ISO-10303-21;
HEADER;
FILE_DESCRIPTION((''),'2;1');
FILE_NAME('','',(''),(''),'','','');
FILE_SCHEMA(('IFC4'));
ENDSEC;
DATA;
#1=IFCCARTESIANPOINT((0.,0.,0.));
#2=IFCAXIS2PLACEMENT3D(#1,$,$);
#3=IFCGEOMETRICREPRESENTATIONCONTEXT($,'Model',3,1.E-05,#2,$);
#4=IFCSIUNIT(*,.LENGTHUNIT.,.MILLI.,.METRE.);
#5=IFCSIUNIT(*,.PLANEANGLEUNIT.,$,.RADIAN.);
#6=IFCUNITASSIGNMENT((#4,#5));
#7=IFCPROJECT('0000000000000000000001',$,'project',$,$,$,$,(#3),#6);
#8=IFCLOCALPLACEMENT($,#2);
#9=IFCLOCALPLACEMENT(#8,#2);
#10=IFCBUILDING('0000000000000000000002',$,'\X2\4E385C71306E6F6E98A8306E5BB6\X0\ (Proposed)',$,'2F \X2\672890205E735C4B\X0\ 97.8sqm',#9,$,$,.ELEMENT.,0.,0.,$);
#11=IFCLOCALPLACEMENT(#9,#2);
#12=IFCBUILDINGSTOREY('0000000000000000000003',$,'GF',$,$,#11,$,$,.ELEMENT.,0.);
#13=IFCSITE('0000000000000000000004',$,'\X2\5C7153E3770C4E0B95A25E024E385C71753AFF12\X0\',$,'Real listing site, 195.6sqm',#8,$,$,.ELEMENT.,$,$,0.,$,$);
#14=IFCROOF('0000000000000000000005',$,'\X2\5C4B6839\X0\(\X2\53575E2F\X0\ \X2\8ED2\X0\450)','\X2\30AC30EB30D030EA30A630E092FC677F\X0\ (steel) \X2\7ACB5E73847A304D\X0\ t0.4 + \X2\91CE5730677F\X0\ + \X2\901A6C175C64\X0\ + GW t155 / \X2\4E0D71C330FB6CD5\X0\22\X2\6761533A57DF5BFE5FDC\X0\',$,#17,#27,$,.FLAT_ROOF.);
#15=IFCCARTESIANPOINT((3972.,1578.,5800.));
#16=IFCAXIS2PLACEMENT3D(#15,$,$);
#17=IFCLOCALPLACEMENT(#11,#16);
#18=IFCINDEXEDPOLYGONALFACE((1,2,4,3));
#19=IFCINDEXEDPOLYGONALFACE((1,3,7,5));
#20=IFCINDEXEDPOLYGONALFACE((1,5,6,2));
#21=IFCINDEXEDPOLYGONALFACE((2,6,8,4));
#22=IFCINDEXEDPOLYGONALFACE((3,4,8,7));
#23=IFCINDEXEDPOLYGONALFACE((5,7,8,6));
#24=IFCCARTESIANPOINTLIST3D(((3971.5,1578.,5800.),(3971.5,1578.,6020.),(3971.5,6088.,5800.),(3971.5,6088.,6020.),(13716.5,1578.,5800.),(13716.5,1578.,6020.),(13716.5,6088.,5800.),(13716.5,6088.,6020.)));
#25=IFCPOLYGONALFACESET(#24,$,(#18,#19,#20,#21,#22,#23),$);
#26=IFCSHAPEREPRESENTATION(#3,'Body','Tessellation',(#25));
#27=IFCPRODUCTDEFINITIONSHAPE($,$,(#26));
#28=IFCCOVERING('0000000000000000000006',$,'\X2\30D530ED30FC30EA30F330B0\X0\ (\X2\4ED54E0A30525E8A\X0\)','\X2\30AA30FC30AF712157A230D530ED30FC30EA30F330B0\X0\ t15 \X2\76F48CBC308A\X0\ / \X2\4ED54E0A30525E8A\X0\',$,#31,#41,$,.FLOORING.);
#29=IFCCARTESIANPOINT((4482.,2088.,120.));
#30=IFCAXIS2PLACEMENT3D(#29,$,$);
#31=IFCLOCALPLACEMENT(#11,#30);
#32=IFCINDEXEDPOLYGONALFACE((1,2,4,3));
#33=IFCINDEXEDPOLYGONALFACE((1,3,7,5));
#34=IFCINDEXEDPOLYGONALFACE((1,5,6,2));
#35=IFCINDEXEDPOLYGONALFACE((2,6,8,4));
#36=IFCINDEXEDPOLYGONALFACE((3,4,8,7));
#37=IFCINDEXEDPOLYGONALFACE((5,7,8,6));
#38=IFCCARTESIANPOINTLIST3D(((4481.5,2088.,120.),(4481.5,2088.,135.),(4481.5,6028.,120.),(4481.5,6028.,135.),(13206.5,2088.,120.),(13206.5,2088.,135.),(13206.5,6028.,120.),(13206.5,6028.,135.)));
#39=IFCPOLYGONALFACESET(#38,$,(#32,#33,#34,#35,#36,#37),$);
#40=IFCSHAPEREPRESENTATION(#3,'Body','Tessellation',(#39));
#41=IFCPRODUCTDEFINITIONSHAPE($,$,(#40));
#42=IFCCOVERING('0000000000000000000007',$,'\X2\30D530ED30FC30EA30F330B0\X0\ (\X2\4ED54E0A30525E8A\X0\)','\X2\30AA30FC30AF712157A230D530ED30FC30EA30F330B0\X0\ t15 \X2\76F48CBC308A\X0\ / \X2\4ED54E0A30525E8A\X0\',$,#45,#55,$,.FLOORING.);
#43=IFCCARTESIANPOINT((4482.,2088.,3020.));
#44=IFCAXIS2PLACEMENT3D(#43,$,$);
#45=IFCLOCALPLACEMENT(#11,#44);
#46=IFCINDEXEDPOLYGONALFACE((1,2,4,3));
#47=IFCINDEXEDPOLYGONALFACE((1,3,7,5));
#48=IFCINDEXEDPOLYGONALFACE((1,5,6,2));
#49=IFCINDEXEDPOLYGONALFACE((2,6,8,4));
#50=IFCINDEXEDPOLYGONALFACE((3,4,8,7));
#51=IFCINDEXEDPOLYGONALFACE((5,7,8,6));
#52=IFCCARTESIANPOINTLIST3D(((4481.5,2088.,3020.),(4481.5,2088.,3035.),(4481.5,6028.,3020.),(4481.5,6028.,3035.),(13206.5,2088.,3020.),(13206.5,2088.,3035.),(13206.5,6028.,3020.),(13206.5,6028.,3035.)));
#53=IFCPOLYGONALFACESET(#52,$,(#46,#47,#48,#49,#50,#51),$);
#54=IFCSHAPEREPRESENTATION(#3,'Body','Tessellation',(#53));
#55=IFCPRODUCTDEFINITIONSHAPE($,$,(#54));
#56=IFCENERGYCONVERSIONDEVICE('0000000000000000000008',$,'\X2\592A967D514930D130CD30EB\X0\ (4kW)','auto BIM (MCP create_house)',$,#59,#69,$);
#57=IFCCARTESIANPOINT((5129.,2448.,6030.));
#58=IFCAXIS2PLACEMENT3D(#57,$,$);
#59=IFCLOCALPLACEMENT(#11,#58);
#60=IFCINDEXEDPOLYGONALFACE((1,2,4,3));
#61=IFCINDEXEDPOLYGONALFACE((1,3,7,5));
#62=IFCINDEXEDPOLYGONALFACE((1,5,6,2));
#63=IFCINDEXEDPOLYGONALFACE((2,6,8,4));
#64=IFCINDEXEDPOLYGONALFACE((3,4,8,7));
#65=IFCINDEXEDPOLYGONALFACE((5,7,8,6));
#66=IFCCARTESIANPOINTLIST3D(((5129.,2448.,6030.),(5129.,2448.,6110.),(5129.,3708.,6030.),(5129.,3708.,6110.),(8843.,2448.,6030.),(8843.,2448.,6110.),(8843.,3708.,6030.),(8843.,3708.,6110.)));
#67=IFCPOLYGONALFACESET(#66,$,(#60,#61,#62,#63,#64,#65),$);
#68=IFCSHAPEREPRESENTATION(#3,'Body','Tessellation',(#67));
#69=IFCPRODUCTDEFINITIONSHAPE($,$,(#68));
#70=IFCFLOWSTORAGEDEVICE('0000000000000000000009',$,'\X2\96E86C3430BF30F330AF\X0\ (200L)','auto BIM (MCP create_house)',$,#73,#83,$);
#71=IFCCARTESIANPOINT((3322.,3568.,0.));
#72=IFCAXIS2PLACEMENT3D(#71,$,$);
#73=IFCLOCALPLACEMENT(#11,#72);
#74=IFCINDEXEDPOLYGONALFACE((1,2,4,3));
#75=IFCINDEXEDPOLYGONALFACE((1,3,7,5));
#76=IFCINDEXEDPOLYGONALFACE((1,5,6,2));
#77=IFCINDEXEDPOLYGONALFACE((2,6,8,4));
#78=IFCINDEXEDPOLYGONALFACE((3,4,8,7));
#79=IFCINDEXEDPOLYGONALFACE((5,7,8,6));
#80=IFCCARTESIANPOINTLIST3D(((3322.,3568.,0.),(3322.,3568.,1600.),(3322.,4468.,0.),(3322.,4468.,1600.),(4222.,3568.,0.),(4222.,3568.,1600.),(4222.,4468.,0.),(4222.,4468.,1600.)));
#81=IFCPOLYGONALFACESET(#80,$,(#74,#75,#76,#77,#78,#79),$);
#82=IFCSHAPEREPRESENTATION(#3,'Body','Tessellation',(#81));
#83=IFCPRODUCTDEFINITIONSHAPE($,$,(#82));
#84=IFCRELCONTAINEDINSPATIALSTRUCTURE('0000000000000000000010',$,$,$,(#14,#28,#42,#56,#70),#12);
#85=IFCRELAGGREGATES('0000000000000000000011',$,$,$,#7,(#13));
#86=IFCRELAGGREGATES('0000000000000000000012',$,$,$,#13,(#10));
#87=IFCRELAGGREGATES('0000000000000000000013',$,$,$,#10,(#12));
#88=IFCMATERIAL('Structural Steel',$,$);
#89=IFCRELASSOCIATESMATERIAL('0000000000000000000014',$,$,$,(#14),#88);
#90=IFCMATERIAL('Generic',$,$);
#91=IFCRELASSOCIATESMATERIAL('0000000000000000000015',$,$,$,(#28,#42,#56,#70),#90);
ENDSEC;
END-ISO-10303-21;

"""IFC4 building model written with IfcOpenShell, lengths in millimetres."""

from ifc_helpers import new_model, si_unit, frame, frame_2d, origin, place, context, project, spatial, rectangle, extrude, material, element, save


model = new_model("IFC4")

# Units and contexts
model_context = context("Model", 3, precision=1e-05, world=origin())
ifc_project = project(units=[si_unit("LENGTHUNIT", "METRE", prefix="MILLI"), si_unit("PLANEANGLEUNIT", "RADIAN")], contexts=[model_context])

# Site, building, storey
site_placement = place(None, origin())
site = spatial("IfcSite", under=ifc_project, at=site_placement, Name="山口県下関市丸山町２", ObjectType="Real listing site, 195.6sqm", CompositionType="ELEMENT", RefElevation=0.0)
building_placement = place(site_placement, origin())
building = spatial("IfcBuilding", under=site, at=building_placement, Name="丸山の潮風の家 (Proposed)", ObjectType="2F 木造平屋 97.8sqm", CompositionType="ELEMENT", ElevationOfRefHeight=0.0, ElevationOfTerrain=0.0)
storey_placement = place(building_placement, origin())
storey = spatial("IfcBuildingStorey", under=building, at=storey_placement, Name="GF", CompositionType="ELEMENT", Elevation=0.0)

# Roof
ifc_material_1 = material(Name="Structural Steel")
for number, where, name in (
    (1, (3972.0, 1578.0, 5800.0), "屋根(南帯 軒450)"),
):
    element("IfcRoof", number, at=place(storey_placement, frame(where)), inside=storey, material=ifc_material_1, Name=name, Description="ガルバリウム鋼板 (steel) 立平葺き t0.4 + 野地板 + 通気層 + GW t155 / 不燃・法22条区域対応", PredefinedType="FLAT_ROOF", context=model_context, shape_type="SweptSolid", body=[
        extrude(rectangle(XDim=9745.0, YDim=4510.0, at=frame_2d((4872.0, 2255.0))), frame((3972.0, 1578.0, 5800.0)), (0.0, 0.0, 1.0), 220.0),
    ])

# Coverings
ifc_material_2 = material(Name="Generic")
covering_1_placement = place(storey_placement, frame((4482.0, 2088.0, 120.0)))
element("IfcCovering", 2, at=covering_1_placement, inside=storey, material=ifc_material_2, Name="フローリング (仕上げ床)", Description="オーク無垢フローリング t15 直貼り / 仕上げ床", PredefinedType="FLOORING", context=model_context, shape_type="SweptSolid", body=[
    extrude(rectangle(XDim=8725.0, YDim=3940.0, at=frame_2d((4362.0, 1970.0))), frame((4482.0, 2088.0, 120.0)), (0.0, 0.0, 1.0), 15.0),
])
covering_2_placement = place(storey_placement, frame((4482.0, 2088.0, 3020.0)))
element("IfcCovering", 3, at=covering_2_placement, inside=storey, material=ifc_material_2, Name="フローリング (仕上げ床)", Description="オーク無垢フローリング t15 直貼り / 仕上げ床", PredefinedType="FLOORING", context=model_context, shape_type="SweptSolid", body=[
    extrude(rectangle(XDim=8725.0, YDim=3940.0, at=frame_2d((4362.0, 1970.0))), frame((4482.0, 2088.0, 3020.0)), (0.0, 0.0, 1.0), 15.0),
])

# Energy conversion device
energy_conversion_device_placement = place(storey_placement, frame((5129.0, 2448.0, 6030.0)))
element("IfcEnergyConversionDevice", 4, at=energy_conversion_device_placement, inside=storey, material=ifc_material_2, Name="太陽光パネル (4kW)", Description="auto BIM (MCP create_house)", context=model_context, shape_type="SweptSolid", body=[
    extrude(rectangle(XDim=3714.0, YDim=1260.0, at=frame_2d((1857.0, 630.0))), frame((5129.0, 2448.0, 6030.0)), (0.0, 0.0, 1.0), 80.0),
])

# Flow storage device
flow_storage_device_placement = place(storey_placement, frame((3322.0, 3568.0, 0.0)))
element("IfcFlowStorageDevice", 5, at=flow_storage_device_placement, inside=storey, material=ifc_material_2, Name="雨水タンク (200L)", Description="auto BIM (MCP create_house)", context=model_context, shape_type="SweptSolid", body=[
    extrude(rectangle(XDim=900.0, YDim=900.0, at=frame_2d((450.0, 450.0))), frame((3322.0, 3568.0, 0.0)), (0.0, 0.0, 1.0), 1600.0),
])

save(model, "model.ifc")
